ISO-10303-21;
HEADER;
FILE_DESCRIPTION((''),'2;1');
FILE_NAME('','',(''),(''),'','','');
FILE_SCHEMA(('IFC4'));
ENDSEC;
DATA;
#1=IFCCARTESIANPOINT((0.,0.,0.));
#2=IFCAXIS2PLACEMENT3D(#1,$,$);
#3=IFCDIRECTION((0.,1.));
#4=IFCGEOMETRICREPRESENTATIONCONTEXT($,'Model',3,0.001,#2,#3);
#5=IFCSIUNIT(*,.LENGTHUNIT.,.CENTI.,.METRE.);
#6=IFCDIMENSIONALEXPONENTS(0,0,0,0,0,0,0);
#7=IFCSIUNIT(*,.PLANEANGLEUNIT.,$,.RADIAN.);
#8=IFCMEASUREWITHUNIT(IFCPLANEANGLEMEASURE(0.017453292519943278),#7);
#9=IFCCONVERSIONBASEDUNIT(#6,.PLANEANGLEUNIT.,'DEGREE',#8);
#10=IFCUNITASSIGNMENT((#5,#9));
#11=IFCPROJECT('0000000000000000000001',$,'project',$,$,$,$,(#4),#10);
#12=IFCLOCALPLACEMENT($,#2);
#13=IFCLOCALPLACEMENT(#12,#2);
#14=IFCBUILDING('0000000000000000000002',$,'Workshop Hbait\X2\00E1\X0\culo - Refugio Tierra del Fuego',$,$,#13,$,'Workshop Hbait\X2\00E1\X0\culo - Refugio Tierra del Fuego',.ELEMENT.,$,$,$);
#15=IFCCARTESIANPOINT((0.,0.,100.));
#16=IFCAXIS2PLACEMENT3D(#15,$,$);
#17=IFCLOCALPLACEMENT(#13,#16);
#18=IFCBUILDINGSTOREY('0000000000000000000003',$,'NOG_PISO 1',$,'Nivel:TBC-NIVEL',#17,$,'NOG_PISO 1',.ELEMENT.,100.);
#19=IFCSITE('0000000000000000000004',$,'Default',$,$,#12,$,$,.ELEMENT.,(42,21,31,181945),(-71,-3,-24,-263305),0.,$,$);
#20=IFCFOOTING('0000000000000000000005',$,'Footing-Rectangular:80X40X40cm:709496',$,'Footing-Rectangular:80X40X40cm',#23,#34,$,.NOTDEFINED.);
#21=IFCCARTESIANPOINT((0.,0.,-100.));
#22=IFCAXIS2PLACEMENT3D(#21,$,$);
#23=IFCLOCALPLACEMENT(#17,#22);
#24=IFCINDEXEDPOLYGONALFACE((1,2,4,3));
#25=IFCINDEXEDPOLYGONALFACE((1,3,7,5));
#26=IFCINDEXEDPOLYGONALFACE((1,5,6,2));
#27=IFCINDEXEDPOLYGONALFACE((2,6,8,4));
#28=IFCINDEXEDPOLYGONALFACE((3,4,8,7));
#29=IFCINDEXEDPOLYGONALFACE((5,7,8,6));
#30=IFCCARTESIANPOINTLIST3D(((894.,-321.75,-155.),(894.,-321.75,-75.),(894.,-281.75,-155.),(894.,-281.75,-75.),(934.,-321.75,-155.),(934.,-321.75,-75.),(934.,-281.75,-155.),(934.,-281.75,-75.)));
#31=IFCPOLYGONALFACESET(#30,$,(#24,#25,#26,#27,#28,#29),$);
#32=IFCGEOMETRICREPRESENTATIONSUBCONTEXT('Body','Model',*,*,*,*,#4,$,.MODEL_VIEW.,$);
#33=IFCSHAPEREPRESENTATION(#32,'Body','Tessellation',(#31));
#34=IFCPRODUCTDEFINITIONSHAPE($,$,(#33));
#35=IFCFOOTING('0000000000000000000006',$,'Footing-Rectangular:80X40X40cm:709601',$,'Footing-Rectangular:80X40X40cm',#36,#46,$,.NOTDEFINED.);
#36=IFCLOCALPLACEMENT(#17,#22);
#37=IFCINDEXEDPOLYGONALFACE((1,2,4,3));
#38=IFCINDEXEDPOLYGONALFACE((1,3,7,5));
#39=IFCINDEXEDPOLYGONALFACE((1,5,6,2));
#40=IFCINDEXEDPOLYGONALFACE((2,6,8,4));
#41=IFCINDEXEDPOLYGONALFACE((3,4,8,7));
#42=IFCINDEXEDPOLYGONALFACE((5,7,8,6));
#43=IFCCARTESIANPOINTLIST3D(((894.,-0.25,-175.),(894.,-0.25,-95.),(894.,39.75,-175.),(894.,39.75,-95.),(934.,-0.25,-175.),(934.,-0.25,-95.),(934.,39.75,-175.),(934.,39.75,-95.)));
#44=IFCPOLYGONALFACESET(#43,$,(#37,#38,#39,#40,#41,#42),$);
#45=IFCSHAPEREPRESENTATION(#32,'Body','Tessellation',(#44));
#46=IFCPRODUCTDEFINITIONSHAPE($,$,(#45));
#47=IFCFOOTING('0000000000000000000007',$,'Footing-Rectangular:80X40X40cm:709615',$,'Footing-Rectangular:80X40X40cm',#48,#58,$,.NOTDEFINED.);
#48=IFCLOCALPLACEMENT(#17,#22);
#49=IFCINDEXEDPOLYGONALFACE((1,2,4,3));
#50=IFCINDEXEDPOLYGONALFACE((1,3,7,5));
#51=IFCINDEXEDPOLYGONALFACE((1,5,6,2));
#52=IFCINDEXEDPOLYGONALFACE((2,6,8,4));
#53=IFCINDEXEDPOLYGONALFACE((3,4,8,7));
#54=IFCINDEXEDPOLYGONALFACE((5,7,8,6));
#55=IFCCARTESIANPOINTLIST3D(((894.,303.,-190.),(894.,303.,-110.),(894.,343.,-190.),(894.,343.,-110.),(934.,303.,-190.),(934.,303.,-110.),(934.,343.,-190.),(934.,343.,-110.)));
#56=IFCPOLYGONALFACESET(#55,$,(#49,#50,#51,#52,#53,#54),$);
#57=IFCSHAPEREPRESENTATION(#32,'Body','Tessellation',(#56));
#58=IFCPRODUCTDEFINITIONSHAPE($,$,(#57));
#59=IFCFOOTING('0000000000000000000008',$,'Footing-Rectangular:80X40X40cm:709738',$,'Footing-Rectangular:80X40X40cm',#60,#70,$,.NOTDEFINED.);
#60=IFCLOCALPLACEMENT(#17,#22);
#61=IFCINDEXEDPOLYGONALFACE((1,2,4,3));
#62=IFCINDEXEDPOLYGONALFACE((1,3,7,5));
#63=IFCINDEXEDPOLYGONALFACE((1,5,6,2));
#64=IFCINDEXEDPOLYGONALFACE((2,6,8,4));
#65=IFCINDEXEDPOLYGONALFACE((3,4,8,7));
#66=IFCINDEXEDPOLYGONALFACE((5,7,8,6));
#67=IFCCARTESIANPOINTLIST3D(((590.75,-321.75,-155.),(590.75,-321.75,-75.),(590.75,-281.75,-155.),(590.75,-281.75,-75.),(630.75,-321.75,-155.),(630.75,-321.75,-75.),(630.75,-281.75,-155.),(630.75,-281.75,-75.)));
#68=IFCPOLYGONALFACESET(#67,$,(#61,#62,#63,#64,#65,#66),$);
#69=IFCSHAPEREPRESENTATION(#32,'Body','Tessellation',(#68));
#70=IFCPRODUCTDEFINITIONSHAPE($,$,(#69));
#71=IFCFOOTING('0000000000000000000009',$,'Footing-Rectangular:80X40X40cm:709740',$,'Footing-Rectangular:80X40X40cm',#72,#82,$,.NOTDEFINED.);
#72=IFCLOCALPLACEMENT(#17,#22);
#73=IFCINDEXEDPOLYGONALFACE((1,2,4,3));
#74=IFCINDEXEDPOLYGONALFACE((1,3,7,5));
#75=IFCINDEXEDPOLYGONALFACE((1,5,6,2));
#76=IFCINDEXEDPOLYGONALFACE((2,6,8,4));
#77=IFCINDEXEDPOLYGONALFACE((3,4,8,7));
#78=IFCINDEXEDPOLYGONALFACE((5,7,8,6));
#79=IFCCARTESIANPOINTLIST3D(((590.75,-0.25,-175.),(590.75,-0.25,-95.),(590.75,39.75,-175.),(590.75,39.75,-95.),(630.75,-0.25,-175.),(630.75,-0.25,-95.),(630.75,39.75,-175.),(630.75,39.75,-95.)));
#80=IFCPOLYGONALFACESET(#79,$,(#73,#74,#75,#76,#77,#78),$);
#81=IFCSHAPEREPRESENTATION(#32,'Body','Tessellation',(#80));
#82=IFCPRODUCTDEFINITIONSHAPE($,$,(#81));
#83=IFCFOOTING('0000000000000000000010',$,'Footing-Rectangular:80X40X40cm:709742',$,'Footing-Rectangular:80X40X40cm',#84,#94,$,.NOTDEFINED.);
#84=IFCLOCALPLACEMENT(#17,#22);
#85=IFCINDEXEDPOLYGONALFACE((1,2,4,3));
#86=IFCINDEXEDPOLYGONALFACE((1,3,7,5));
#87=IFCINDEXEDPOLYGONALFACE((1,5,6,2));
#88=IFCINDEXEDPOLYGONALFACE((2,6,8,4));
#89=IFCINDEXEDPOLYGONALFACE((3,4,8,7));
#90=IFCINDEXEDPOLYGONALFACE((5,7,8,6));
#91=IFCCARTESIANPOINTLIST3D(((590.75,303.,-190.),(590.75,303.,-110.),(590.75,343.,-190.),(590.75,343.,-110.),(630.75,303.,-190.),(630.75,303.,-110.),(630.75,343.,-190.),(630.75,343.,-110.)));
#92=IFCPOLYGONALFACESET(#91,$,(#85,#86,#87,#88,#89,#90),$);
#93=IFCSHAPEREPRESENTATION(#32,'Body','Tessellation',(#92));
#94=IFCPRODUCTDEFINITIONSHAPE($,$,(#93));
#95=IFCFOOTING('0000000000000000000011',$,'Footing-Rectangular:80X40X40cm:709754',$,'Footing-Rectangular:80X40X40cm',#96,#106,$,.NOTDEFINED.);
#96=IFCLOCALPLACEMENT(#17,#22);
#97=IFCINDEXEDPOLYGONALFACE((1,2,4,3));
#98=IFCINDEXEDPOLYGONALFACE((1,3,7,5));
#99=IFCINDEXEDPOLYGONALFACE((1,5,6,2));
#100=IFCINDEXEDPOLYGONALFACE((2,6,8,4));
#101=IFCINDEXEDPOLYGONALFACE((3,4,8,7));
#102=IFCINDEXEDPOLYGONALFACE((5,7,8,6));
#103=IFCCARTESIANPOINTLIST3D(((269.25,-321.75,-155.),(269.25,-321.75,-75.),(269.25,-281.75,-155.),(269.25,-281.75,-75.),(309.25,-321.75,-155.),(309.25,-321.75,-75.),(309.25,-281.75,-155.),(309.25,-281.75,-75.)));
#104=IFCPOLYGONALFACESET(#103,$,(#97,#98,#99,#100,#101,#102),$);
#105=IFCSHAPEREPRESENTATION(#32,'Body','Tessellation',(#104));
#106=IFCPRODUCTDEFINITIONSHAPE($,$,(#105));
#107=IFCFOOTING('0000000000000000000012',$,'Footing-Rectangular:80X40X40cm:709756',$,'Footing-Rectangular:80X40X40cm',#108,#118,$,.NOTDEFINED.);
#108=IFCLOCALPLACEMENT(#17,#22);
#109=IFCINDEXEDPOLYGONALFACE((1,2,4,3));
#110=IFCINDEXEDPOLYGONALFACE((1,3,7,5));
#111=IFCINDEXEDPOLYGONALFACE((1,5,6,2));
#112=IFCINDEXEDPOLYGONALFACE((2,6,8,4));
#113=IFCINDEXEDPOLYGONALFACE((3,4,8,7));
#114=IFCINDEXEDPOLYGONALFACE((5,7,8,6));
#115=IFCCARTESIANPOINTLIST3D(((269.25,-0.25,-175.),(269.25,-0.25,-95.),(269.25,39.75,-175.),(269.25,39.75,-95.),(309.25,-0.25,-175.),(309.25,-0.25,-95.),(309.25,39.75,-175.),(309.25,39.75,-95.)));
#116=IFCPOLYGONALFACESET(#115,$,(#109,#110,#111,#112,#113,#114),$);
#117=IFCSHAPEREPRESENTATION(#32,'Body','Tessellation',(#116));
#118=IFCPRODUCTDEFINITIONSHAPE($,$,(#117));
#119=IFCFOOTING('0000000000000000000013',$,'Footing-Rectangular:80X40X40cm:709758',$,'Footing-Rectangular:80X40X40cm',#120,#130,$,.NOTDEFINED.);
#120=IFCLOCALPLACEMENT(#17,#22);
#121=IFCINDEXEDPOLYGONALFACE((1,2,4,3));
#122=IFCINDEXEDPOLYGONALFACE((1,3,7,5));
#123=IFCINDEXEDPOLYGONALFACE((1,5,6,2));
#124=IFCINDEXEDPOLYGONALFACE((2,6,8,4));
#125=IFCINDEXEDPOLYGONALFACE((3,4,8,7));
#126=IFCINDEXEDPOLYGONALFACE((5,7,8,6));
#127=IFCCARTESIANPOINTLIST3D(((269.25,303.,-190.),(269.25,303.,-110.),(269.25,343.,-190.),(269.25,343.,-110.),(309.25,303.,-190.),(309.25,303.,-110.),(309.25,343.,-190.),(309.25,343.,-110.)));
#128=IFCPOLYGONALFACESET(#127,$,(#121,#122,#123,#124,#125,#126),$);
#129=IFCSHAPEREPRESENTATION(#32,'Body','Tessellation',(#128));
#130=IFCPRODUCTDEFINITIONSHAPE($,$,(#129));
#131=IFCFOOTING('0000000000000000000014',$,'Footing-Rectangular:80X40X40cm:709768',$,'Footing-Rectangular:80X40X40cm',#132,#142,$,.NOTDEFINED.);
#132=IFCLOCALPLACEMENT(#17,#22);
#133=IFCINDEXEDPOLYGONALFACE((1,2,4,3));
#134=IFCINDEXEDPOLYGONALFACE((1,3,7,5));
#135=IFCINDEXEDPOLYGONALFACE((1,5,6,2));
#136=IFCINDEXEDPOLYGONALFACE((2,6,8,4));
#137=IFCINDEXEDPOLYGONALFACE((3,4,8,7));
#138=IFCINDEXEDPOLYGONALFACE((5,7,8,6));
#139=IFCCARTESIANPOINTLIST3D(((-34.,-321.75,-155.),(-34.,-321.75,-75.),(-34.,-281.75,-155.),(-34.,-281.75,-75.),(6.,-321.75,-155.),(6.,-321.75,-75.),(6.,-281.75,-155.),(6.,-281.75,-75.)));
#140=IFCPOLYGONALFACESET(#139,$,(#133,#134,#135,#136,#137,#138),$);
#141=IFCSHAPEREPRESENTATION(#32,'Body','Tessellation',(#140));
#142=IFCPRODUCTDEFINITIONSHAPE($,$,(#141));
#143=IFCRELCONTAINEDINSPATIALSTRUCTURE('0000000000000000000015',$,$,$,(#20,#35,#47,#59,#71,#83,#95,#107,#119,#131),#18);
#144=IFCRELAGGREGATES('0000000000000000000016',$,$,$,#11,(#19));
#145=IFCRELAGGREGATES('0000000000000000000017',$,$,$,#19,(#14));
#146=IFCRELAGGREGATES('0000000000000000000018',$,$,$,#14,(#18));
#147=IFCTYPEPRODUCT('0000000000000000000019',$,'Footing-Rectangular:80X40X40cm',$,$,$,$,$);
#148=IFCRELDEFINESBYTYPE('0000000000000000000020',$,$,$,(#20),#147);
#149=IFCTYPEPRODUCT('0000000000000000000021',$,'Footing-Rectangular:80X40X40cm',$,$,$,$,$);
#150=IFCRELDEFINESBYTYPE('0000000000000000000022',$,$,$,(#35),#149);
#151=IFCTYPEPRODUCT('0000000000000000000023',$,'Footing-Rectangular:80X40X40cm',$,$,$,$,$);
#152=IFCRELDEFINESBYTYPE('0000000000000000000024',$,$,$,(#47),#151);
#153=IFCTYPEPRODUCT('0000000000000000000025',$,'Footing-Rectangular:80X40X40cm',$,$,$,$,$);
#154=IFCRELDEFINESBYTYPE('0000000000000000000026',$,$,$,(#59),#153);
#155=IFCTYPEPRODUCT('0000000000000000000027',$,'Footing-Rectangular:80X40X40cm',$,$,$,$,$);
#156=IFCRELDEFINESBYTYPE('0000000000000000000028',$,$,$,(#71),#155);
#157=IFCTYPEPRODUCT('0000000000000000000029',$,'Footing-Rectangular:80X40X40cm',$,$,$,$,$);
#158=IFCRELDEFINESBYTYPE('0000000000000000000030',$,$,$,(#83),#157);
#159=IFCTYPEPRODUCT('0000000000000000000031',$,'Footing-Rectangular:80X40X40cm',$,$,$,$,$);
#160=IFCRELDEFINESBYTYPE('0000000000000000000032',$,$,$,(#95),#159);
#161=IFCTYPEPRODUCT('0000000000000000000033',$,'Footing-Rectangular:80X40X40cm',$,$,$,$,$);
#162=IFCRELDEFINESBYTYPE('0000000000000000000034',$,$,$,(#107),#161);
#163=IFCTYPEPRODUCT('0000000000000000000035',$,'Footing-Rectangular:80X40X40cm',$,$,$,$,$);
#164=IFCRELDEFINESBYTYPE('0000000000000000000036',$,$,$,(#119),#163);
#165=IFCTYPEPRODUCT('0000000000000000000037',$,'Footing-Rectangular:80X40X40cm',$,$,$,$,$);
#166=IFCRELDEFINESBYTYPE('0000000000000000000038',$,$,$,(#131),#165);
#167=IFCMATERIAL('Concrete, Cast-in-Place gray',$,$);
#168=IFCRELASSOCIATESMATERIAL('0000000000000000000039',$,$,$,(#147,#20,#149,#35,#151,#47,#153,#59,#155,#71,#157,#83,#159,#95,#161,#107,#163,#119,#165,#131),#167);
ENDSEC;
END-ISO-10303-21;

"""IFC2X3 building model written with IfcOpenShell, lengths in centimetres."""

from ifc_helpers import new_model, entity, si_unit, converted_unit, direction, frame, frame_2d, origin, origin_2d_with_axis, place, context, subcontext, project, spatial, rectangle, extrude, source, transform, mapped, material, type_object, type_shapes, element, save


model = new_model("IFC2X3")

# Units and contexts
model_context = context("Model", 3, precision=0.001, world=origin(), true_north=direction((0.0, 1.0)))
body_context = subcontext(model_context, "Body", "Model", "MODEL_VIEW")
ifc_project = project(units=[si_unit("LENGTHUNIT", "METRE", prefix="CENTI"), converted_unit("PLANEANGLEUNIT", "DEGREE", entity("IfcPlaneAngleMeasure", 0.017453292519943278), si_unit("PLANEANGLEUNIT", "RADIAN"), dimensions=[0, 0, 0, 0, 0, 0, 0])], contexts=[model_context])

# Site, building, storey
site_placement = place(None, origin())
site = spatial("IfcSite", under=ifc_project, at=site_placement, Name="Default", CompositionType="ELEMENT", RefLatitude=(42, 21, 31, 181945), RefLongitude=(-71, -3, -24, -263305), RefElevation=0.0)
building_placement = place(site_placement, origin())
building = spatial("IfcBuilding", under=site, at=building_placement, Name="Workshop Hbaitáculo - Refugio Tierra del Fuego", LongName="Workshop Hbaitáculo - Refugio Tierra del Fuego", CompositionType="ELEMENT")
storey_placement = place(building_placement, frame((0.0, 0.0, 100.0)))
storey = spatial("IfcBuildingStorey", under=building, at=storey_placement, Name="NOG_PISO 1", ObjectType="Nivel:TBC-NIVEL", LongName="NOG_PISO 1", CompositionType="ELEMENT", Elevation=100.0)

# Footings
ifc_material_1 = material(Name="Concrete, Cast-in-Place gray")
type_product_1 = type_object("IfcTypeProduct", Name="Footing-Rectangular:80X40X40cm", material=ifc_material_1)
shared_shape_1 = source(origin(), body_context, "Body", "SweptSolid", [
    extrude(rectangle(XDim=40.0, YDim=40.0, at=origin_2d_with_axis()), frame((914.0, -301.75, -155.0), z_axis=(0.0, 0.0, 1.0), x_axis=(-1.0, 0.0, 0.0)), (0.0, 0.0, 1.0), 80.0),
])
type_shapes(type_product_1, [shared_shape_1])
footing_1_placement = place(storey_placement, frame((0.0, 0.0, -100.0)))
element("IfcFooting", 1, at=footing_1_placement, inside=storey, type_object=type_product_1, material=ifc_material_1, Name="Footing-Rectangular:80X40X40cm:709496", ObjectType="Footing-Rectangular:80X40X40cm", PredefinedType="NOTDEFINED", context=body_context, shape_type="MappedRepresentation", body=[
    mapped(shared_shape_1, transform((0.0, 0.0, 0.0), scale=1.0)),
])
type_product_2 = type_object("IfcTypeProduct", Name="Footing-Rectangular:80X40X40cm", material=ifc_material_1)
shared_shape_2 = source(origin(), body_context, "Body", "SweptSolid", [
    extrude(rectangle(XDim=40.0, YDim=40.0, at=origin_2d_with_axis()), frame((914.0, 19.75, -175.0), z_axis=(0.0, 0.0, 1.0), x_axis=(-1.0, 0.0, 0.0)), (0.0, 0.0, 1.0), 80.0),
])
type_shapes(type_product_2, [shared_shape_2])
footing_2_placement = place(storey_placement, frame((0.0, 0.0, -100.0)))
element("IfcFooting", 2, at=footing_2_placement, inside=storey, type_object=type_product_2, material=ifc_material_1, Name="Footing-Rectangular:80X40X40cm:709601", ObjectType="Footing-Rectangular:80X40X40cm", PredefinedType="NOTDEFINED", context=body_context, shape_type="MappedRepresentation", body=[
    mapped(shared_shape_2, transform((0.0, 0.0, 0.0), scale=1.0)),
])
type_product_3 = type_object("IfcTypeProduct", Name="Footing-Rectangular:80X40X40cm", material=ifc_material_1)
shared_shape_3 = source(origin(), body_context, "Body", "SweptSolid", [
    extrude(rectangle(XDim=40.0, YDim=40.0, at=origin_2d_with_axis()), frame((914.0, 323.0, -190.0), z_axis=(0.0, 0.0, 1.0), x_axis=(-1.0, 0.0, 0.0)), (0.0, 0.0, 1.0), 80.0),
])
type_shapes(type_product_3, [shared_shape_3])
footing_3_placement = place(storey_placement, frame((0.0, 0.0, -100.0)))
element("IfcFooting", 3, at=footing_3_placement, inside=storey, type_object=type_product_3, material=ifc_material_1, Name="Footing-Rectangular:80X40X40cm:709615", ObjectType="Footing-Rectangular:80X40X40cm", PredefinedType="NOTDEFINED", context=body_context, shape_type="MappedRepresentation", body=[
    mapped(shared_shape_3, transform((0.0, 0.0, 0.0), scale=1.0)),
])
type_product_4 = type_object("IfcTypeProduct", Name="Footing-Rectangular:80X40X40cm", material=ifc_material_1)
shared_shape_4 = source(origin(), body_context, "Body", "SweptSolid", [
    extrude(rectangle(XDim=40.0, YDim=40.0, at=origin_2d_with_axis()), frame((610.75, -301.75, -155.0), z_axis=(0.0, 0.0, 1.0), x_axis=(-1.0, 0.0, 0.0)), (0.0, 0.0, 1.0), 80.0),
])
type_shapes(type_product_4, [shared_shape_4])
footing_4_placement = place(storey_placement, frame((0.0, 0.0, -100.0)))
element("IfcFooting", 4, at=footing_4_placement, inside=storey, type_object=type_product_4, material=ifc_material_1, Name="Footing-Rectangular:80X40X40cm:709738", ObjectType="Footing-Rectangular:80X40X40cm", PredefinedType="NOTDEFINED", context=body_context, shape_type="MappedRepresentation", body=[
    mapped(shared_shape_4, transform((0.0, 0.0, 0.0), scale=1.0)),
])
type_product_5 = type_object("IfcTypeProduct", Name="Footing-Rectangular:80X40X40cm", material=ifc_material_1)
shared_shape_5 = source(origin(), body_context, "Body", "SweptSolid", [
    extrude(rectangle(XDim=40.0, YDim=40.0, at=origin_2d_with_axis()), frame((610.75, 19.75, -175.0), z_axis=(0.0, 0.0, 1.0), x_axis=(-1.0, 0.0, 0.0)), (0.0, 0.0, 1.0), 80.0),
])
type_shapes(type_product_5, [shared_shape_5])
footing_5_placement = place(storey_placement, frame((0.0, 0.0, -100.0)))
element("IfcFooting", 5, at=footing_5_placement, inside=storey, type_object=type_product_5, material=ifc_material_1, Name="Footing-Rectangular:80X40X40cm:709740", ObjectType="Footing-Rectangular:80X40X40cm", PredefinedType="NOTDEFINED", context=body_context, shape_type="MappedRepresentation", body=[
    mapped(shared_shape_5, transform((0.0, 0.0, 0.0), scale=1.0)),
])
type_product_6 = type_object("IfcTypeProduct", Name="Footing-Rectangular:80X40X40cm", material=ifc_material_1)
shared_shape_6 = source(origin(), body_context, "Body", "SweptSolid", [
    extrude(rectangle(XDim=40.0, YDim=40.0, at=origin_2d_with_axis()), frame((610.75, 323.0, -190.0), z_axis=(0.0, 0.0, 1.0), x_axis=(-1.0, 0.0, 0.0)), (0.0, 0.0, 1.0), 80.0),
])
type_shapes(type_product_6, [shared_shape_6])
footing_6_placement = place(storey_placement, frame((0.0, 0.0, -100.0)))
element("IfcFooting", 6, at=footing_6_placement, inside=storey, type_object=type_product_6, material=ifc_material_1, Name="Footing-Rectangular:80X40X40cm:709742", ObjectType="Footing-Rectangular:80X40X40cm", PredefinedType="NOTDEFINED", context=body_context, shape_type="MappedRepresentation", body=[
    mapped(shared_shape_6, transform((0.0, 0.0, 0.0), scale=1.0)),
])
type_product_7 = type_object("IfcTypeProduct", Name="Footing-Rectangular:80X40X40cm", material=ifc_material_1)
shared_shape_7 = source(origin(), body_context, "Body", "SweptSolid", [
    extrude(rectangle(XDim=40.0, YDim=40.0, at=origin_2d_with_axis()), frame((289.25, -301.75, -155.0), z_axis=(0.0, 0.0, 1.0), x_axis=(-1.0, 0.0, 0.0)), (0.0, 0.0, 1.0), 80.0),
])
type_shapes(type_product_7, [shared_shape_7])
footing_7_placement = place(storey_placement, frame((0.0, 0.0, -100.0)))
element("IfcFooting", 7, at=footing_7_placement, inside=storey, type_object=type_product_7, material=ifc_material_1, Name="Footing-Rectangular:80X40X40cm:709754", ObjectType="Footing-Rectangular:80X40X40cm", PredefinedType="NOTDEFINED", context=body_context, shape_type="MappedRepresentation", body=[
    mapped(shared_shape_7, transform((0.0, 0.0, 0.0), scale=1.0)),
])
type_product_8 = type_object("IfcTypeProduct", Name="Footing-Rectangular:80X40X40cm", material=ifc_material_1)
shared_shape_8 = source(origin(), body_context, "Body", "SweptSolid", [
    extrude(rectangle(XDim=40.0, YDim=40.0, at=origin_2d_with_axis()), frame((289.25, 19.75, -175.0), z_axis=(0.0, 0.0, 1.0), x_axis=(-1.0, 0.0, 0.0)), (0.0, 0.0, 1.0), 80.0),
])
type_shapes(type_product_8, [shared_shape_8])
footing_8_placement = place(storey_placement, frame((0.0, 0.0, -100.0)))
element("IfcFooting", 8, at=footing_8_placement, inside=storey, type_object=type_product_8, material=ifc_material_1, Name="Footing-Rectangular:80X40X40cm:709756", ObjectType="Footing-Rectangular:80X40X40cm", PredefinedType="NOTDEFINED", context=body_context, shape_type="MappedRepresentation", body=[
    mapped(shared_shape_8, transform((0.0, 0.0, 0.0), scale=1.0)),
])
type_product_9 = type_object("IfcTypeProduct", Name="Footing-Rectangular:80X40X40cm", material=ifc_material_1)
shared_shape_9 = source(origin(), body_context, "Body", "SweptSolid", [
    extrude(rectangle(XDim=40.0, YDim=40.0, at=origin_2d_with_axis()), frame((289.25, 323.0, -190.0), z_axis=(0.0, 0.0, 1.0), x_axis=(-1.0, 0.0, 0.0)), (0.0, 0.0, 1.0), 80.0),
])
type_shapes(type_product_9, [shared_shape_9])
footing_9_placement = place(storey_placement, frame((0.0, 0.0, -100.0)))
element("IfcFooting", 9, at=footing_9_placement, inside=storey, type_object=type_product_9, material=ifc_material_1, Name="Footing-Rectangular:80X40X40cm:709758", ObjectType="Footing-Rectangular:80X40X40cm", PredefinedType="NOTDEFINED", context=body_context, shape_type="MappedRepresentation", body=[
    mapped(shared_shape_9, transform((0.0, 0.0, 0.0), scale=1.0)),
])
type_product_10 = type_object("IfcTypeProduct", Name="Footing-Rectangular:80X40X40cm", material=ifc_material_1)
shared_shape_10 = source(origin(), body_context, "Body", "SweptSolid", [
    extrude(rectangle(XDim=40.0, YDim=40.0, at=frame_2d((0.0, 0.0), x_axis=(1.0, 0.0))), frame((-14.0, -301.75, -155.0), z_axis=(0.0, 0.0, 1.0), x_axis=(-1.0, 0.0, 0.0)), (0.0, 0.0, 1.0), 80.0),
])
type_shapes(type_product_10, [shared_shape_10])
footing_10_placement = place(storey_placement, frame((0.0, 0.0, -100.0)))
element("IfcFooting", 10, at=footing_10_placement, inside=storey, type_object=type_product_10, material=ifc_material_1, Name="Footing-Rectangular:80X40X40cm:709768", ObjectType="Footing-Rectangular:80X40X40cm", PredefinedType="NOTDEFINED", context=body_context, shape_type="MappedRepresentation", body=[
    mapped(shared_shape_10, transform((0.0, 0.0, 0.0), scale=1.0)),
])

save(model, "model.ifc")
